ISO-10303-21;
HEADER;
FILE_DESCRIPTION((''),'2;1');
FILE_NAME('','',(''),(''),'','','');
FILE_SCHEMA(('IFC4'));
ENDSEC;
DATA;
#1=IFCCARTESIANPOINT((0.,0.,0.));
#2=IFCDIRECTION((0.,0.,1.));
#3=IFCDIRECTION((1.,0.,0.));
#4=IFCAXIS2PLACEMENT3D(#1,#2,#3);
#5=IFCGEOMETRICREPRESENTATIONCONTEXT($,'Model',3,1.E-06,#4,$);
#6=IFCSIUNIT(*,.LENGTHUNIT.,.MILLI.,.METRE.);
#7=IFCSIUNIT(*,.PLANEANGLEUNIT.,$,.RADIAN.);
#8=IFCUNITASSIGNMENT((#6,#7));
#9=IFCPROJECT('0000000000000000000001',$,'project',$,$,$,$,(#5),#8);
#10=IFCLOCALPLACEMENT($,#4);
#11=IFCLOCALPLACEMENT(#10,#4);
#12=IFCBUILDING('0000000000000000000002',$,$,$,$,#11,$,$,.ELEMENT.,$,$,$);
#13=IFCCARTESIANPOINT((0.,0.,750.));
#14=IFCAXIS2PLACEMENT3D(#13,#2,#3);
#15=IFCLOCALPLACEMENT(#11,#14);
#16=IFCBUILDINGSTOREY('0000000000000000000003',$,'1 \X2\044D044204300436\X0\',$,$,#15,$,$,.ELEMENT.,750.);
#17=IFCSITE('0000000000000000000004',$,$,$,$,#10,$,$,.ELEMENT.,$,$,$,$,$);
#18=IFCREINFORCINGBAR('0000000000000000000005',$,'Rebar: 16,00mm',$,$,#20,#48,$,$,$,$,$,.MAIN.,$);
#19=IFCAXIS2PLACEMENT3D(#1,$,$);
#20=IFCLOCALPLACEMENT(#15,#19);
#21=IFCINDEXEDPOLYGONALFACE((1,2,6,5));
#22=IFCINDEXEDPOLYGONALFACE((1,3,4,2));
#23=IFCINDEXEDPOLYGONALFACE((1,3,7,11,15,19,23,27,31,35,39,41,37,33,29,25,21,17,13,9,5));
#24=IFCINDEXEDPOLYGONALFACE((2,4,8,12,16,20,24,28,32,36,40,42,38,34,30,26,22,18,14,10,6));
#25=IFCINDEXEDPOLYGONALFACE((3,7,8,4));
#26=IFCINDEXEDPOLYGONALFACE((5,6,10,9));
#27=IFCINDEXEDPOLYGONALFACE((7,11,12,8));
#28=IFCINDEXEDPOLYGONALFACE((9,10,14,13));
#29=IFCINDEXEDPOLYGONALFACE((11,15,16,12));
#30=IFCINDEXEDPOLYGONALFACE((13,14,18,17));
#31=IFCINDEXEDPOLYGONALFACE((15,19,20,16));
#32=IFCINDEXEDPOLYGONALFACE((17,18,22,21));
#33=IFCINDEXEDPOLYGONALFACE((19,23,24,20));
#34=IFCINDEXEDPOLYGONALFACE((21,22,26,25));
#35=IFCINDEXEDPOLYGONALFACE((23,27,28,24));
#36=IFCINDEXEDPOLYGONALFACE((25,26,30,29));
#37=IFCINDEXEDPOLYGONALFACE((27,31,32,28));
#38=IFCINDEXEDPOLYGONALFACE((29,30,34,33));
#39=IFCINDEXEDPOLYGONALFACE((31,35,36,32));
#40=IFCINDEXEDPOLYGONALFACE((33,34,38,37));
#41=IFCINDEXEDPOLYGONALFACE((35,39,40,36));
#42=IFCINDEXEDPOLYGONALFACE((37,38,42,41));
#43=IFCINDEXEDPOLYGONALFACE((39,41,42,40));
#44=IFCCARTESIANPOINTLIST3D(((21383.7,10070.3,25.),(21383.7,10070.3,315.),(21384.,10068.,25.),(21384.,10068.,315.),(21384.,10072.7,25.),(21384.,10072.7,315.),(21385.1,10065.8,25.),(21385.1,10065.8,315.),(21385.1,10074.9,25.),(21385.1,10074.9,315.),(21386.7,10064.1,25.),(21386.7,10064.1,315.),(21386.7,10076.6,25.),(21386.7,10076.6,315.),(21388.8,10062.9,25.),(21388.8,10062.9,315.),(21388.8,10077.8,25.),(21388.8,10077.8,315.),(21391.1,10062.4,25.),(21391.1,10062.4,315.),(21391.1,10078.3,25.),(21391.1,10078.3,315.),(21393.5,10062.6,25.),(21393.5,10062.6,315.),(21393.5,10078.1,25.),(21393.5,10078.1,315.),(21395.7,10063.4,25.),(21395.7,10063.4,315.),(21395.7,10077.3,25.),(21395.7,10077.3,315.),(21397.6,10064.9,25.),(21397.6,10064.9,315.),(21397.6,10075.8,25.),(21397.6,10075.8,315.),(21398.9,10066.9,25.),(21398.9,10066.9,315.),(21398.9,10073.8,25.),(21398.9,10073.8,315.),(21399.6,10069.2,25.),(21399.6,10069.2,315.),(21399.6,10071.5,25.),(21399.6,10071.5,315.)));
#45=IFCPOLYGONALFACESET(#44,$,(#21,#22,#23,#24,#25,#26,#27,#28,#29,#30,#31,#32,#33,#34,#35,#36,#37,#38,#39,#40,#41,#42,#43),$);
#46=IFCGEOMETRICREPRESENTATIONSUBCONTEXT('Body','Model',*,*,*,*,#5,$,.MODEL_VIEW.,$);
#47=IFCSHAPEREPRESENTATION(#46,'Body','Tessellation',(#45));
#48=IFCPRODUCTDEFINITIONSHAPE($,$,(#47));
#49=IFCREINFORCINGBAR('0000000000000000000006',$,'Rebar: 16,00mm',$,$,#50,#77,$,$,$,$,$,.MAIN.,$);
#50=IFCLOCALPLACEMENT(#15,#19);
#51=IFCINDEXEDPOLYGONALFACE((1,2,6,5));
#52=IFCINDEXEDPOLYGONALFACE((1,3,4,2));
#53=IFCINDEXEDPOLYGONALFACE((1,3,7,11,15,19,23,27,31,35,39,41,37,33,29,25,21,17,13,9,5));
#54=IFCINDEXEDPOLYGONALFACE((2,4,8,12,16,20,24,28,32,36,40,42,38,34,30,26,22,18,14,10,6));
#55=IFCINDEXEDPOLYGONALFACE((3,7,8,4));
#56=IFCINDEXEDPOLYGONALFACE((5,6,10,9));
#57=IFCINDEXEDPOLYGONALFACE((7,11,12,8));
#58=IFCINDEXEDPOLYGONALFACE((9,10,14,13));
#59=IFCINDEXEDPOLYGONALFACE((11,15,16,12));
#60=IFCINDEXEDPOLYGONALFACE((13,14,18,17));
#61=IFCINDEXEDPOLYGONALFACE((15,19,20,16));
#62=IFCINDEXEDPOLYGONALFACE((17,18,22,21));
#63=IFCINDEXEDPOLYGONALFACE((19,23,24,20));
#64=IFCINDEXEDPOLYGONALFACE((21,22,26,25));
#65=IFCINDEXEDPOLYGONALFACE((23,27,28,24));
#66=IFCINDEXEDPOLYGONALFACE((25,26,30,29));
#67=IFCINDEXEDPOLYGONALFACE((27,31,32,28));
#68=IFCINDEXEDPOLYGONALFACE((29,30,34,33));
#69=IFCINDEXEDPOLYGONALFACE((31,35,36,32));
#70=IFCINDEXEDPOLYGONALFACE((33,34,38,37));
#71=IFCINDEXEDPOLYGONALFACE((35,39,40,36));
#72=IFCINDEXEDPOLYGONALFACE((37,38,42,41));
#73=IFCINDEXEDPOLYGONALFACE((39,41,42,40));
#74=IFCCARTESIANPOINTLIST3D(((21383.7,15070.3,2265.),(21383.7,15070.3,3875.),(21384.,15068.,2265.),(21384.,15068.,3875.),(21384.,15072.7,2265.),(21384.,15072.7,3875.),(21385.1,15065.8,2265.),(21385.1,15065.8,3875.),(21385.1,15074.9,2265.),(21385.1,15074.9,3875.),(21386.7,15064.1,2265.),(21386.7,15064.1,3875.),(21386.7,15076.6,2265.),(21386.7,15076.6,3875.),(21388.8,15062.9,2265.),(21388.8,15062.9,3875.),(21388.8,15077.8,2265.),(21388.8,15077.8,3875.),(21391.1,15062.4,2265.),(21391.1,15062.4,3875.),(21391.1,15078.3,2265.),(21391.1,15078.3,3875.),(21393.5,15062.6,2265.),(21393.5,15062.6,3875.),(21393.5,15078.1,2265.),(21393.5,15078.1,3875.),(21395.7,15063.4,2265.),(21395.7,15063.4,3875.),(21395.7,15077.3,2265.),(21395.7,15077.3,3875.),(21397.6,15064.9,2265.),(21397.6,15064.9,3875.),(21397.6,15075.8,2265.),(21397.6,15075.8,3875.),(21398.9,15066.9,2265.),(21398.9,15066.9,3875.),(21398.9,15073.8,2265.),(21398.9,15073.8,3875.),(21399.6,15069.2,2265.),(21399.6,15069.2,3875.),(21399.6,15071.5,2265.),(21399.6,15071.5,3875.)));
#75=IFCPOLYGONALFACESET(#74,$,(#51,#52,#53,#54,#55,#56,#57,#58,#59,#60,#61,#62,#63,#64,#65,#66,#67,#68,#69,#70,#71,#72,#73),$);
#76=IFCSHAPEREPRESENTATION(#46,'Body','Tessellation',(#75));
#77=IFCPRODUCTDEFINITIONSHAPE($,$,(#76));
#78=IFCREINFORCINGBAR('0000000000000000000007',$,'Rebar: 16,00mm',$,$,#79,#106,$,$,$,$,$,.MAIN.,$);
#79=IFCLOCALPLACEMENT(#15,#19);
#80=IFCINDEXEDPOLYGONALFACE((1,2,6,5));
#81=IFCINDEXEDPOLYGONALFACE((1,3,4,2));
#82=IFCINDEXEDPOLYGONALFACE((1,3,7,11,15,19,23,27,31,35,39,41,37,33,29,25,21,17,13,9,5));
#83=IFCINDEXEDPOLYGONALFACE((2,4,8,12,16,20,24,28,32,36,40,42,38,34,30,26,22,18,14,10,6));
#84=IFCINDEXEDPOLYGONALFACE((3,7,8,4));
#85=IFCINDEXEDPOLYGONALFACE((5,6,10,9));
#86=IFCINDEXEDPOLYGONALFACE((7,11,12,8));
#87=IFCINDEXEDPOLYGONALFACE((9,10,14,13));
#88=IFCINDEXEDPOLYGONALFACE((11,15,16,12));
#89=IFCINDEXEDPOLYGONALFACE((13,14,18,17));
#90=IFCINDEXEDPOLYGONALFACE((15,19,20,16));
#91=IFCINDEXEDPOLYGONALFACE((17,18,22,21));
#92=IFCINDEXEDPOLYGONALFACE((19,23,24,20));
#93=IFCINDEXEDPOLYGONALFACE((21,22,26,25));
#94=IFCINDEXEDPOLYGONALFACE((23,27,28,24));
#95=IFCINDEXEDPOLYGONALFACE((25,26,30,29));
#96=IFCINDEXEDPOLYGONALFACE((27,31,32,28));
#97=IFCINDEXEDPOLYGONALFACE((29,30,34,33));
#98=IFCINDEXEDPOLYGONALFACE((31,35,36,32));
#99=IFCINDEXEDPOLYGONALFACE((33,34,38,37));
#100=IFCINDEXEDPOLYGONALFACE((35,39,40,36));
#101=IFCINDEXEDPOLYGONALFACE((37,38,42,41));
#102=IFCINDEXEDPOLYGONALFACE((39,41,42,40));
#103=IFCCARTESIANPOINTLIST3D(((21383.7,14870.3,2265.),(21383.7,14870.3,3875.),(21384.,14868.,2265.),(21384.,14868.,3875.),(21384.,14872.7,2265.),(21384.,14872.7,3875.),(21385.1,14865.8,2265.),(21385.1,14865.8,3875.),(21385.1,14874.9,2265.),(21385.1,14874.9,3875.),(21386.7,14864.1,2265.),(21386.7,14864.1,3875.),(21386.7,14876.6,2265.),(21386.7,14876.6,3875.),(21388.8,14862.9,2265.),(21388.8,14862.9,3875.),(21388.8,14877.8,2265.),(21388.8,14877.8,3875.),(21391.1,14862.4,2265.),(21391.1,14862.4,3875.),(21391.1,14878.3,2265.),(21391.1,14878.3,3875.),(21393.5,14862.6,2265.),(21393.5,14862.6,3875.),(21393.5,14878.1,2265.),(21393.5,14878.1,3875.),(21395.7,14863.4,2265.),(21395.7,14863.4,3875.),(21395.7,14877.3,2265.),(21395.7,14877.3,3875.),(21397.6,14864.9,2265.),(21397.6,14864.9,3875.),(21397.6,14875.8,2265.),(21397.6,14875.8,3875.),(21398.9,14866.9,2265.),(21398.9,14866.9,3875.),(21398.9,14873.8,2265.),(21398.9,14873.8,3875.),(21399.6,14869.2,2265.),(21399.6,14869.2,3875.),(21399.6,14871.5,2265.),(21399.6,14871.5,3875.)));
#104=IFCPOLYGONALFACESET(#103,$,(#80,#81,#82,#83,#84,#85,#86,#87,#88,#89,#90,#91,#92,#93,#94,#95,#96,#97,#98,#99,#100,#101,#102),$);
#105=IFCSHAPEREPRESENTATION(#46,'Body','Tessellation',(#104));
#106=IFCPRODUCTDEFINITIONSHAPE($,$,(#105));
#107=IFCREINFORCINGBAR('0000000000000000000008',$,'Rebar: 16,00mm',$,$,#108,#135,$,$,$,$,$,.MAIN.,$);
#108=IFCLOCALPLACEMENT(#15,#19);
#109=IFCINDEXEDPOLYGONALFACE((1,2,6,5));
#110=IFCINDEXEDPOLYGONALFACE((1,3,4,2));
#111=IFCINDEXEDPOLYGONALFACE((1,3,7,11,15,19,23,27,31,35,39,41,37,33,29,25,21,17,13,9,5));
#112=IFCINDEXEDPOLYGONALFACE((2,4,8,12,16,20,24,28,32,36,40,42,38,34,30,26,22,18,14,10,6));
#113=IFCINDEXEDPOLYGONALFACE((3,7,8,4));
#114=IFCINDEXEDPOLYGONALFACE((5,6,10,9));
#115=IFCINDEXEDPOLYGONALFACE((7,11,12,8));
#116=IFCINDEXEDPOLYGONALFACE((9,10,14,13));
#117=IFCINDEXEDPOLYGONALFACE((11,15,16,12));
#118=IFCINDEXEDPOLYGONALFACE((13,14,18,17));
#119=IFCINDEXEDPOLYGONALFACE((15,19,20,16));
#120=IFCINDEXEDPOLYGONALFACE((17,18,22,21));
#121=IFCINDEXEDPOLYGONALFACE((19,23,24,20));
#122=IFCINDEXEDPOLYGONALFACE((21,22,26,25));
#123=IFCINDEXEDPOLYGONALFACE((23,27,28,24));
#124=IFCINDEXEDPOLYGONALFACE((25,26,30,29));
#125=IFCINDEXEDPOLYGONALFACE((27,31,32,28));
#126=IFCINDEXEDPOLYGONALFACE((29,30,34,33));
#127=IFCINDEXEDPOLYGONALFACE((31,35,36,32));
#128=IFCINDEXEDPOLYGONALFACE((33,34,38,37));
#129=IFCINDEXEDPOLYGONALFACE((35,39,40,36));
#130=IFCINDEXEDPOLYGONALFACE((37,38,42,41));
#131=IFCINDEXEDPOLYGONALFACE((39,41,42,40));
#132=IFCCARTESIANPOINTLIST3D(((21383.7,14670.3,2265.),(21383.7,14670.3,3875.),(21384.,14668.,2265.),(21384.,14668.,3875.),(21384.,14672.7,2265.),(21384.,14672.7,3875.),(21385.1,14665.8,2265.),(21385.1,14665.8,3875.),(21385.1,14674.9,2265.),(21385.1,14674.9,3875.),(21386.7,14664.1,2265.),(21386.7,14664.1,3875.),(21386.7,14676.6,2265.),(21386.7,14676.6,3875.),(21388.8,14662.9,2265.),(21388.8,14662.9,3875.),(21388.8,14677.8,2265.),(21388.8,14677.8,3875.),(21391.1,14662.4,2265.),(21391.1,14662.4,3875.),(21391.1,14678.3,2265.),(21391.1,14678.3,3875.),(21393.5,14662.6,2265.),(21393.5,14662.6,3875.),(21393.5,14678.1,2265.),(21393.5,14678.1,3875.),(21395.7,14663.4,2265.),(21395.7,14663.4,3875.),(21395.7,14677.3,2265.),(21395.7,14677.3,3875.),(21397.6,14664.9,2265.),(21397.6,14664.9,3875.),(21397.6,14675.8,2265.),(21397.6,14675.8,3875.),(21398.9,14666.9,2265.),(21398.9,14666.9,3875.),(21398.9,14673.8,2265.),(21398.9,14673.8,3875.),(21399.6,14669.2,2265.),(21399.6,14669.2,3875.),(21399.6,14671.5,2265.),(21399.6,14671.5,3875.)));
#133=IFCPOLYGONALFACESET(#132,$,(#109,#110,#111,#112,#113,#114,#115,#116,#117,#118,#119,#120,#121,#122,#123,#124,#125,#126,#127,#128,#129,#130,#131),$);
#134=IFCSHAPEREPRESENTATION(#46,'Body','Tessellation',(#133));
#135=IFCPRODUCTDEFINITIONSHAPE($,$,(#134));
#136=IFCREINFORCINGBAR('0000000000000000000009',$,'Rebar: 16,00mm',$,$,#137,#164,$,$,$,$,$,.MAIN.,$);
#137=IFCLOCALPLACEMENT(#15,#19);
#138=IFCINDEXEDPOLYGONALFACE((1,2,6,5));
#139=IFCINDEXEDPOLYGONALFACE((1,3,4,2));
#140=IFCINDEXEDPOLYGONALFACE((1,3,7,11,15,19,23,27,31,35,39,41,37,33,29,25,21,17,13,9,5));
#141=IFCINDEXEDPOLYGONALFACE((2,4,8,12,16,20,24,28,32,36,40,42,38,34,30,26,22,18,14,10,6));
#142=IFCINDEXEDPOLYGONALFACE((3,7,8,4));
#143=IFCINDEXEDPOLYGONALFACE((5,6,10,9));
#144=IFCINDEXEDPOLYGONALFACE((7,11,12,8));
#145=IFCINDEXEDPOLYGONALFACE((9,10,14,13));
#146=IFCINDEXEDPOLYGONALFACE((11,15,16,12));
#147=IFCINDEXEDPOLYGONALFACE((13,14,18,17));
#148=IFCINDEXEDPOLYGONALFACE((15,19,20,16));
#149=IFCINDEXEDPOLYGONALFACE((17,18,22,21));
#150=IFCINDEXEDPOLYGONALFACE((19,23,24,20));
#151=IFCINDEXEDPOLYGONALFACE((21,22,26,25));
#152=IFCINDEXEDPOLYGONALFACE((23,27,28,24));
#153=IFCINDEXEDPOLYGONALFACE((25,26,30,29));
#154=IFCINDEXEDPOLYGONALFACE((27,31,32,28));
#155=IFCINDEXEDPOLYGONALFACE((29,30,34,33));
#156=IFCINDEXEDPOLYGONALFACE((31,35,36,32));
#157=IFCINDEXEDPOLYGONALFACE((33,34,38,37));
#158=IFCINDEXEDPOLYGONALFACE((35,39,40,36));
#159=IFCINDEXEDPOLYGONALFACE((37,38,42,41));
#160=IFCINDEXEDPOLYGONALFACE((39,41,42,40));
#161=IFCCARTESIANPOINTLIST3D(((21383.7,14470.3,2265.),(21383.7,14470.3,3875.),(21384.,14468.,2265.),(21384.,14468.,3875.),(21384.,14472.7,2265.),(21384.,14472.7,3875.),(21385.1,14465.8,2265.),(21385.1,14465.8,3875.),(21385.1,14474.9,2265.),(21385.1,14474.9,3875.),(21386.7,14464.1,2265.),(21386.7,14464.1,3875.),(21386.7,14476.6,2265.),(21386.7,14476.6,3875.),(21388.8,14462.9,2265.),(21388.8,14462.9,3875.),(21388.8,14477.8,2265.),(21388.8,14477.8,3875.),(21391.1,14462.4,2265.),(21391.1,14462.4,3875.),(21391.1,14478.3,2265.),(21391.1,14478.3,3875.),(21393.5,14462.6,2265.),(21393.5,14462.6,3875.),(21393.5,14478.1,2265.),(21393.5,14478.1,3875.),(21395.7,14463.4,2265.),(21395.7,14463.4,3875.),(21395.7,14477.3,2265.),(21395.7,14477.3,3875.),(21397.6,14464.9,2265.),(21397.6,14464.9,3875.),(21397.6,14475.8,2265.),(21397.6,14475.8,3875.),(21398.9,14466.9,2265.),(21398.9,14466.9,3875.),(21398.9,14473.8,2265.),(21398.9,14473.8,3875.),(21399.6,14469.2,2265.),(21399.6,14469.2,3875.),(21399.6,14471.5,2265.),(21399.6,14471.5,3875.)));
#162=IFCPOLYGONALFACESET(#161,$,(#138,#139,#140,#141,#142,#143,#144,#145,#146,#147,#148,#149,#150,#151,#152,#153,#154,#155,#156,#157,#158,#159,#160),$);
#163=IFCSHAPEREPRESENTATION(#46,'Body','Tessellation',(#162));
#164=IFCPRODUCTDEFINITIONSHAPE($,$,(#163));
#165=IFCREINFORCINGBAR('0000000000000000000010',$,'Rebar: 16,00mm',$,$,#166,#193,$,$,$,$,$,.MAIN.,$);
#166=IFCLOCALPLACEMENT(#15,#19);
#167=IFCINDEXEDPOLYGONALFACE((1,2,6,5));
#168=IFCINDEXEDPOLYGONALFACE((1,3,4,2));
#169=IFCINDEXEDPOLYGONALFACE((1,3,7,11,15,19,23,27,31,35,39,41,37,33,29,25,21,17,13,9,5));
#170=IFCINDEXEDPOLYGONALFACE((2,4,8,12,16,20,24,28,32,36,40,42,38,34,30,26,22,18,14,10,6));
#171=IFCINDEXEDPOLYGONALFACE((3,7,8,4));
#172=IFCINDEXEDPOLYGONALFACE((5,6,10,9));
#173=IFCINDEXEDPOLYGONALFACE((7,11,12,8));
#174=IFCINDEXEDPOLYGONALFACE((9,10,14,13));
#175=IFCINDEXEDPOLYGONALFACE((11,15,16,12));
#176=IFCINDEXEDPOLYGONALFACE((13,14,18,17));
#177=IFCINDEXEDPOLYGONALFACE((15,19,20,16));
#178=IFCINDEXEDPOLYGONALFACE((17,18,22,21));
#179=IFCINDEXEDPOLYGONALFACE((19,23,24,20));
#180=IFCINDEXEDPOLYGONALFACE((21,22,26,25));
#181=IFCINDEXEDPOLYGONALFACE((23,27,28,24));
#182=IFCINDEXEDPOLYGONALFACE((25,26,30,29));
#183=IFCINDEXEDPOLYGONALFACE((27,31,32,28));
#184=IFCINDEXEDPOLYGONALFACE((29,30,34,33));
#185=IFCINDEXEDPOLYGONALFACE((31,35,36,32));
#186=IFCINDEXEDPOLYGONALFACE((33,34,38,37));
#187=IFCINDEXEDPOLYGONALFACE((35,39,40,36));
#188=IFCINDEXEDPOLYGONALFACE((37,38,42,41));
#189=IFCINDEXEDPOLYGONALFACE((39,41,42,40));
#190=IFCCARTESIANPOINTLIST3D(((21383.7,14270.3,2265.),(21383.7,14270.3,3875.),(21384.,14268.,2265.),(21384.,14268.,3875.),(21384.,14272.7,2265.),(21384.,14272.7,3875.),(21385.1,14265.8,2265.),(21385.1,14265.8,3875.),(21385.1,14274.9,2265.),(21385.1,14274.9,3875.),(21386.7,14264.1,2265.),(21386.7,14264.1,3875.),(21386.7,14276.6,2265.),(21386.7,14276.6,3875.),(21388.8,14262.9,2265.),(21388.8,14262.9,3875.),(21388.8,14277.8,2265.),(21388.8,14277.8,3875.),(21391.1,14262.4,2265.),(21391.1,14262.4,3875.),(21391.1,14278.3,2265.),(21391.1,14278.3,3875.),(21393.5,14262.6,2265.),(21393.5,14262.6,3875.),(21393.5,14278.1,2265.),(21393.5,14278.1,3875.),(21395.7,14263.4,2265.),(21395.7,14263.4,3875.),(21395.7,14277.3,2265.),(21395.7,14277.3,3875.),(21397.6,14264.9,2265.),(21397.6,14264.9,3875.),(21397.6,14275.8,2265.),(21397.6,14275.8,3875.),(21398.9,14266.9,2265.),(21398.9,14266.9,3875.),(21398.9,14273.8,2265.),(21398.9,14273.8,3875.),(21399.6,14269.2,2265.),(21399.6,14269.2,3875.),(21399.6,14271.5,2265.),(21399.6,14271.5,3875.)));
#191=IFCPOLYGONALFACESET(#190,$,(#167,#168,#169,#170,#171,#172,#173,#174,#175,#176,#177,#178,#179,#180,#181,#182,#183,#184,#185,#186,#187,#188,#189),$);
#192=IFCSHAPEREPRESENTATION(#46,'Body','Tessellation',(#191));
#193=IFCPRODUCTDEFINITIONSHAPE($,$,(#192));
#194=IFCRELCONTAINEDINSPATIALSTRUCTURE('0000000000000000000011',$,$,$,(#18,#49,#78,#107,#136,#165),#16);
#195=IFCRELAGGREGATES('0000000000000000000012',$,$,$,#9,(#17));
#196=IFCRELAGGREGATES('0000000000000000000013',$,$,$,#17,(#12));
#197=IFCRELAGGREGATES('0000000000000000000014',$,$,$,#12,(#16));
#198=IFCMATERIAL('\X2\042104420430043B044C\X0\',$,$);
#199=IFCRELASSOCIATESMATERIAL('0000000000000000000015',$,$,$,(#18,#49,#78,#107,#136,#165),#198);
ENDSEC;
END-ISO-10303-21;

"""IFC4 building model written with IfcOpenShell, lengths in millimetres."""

from ifc_helpers import new_model, entity, si_unit, frame, origin_with_axes, place, context, subcontext, project, spatial, source, transform, mapped, material, element, save


model = new_model("IFC4")

# Units and contexts
model_context = context("Model", 3, precision=1e-06, world=origin_with_axes())
body_context = subcontext(model_context, "Body", "Model", "MODEL_VIEW")
ifc_project = project(units=[si_unit("LENGTHUNIT", "METRE", prefix="MILLI"), si_unit("PLANEANGLEUNIT", "RADIAN")], contexts=[model_context])

# Site, building, storey
site_placement = place(None, origin_with_axes())
site = spatial("IfcSite", under=ifc_project, at=site_placement, CompositionType="ELEMENT")
building_placement = place(site_placement, origin_with_axes())
building = spatial("IfcBuilding", under=site, at=building_placement, CompositionType="ELEMENT")
storey_placement = place(building_placement, frame((0.0, 0.0, 750.0), z_axis=(0.0, 0.0, 1.0), x_axis=(1.0, 0.0, 0.0)))
storey = spatial("IfcBuildingStorey", under=building, at=storey_placement, Name="1 этаж", CompositionType="ELEMENT", Elevation=750.0)

# Reinforcing bars
ifc_material = material(Name="Сталь")
shared_shape_1 = source(origin_with_axes(), body_context, "Body", "AdvancedSweptSolid", [
    entity("IfcSweptDiskSolid", entity("IfcIndexedPolyCurve", entity("IfcCartesianPointList3D", [[0.0, 0.0, 0.0], [290.0, 0.0, 0.0]]), [entity("IfcLineIndex", [1, 2])]), 8.0),
])
reinforcing_bar_1_placement = place(storey_placement, origin_with_axes())
element("IfcReinforcingBar", 1, at=reinforcing_bar_1_placement, inside=storey, material=ifc_material, Name="Rebar: 16,00mm", PredefinedType="MAIN", context=body_context, shape_type="MappedRepresentation", body=[
    mapped(shared_shape_1, transform((21391.7, 10070.3, 25.0), x_axis=(0.0, 0.0, 1.0), y_axis=(0.0, 1.0, 0.0), z_axis=(-1.0, 0.0, 0.0), scale=1.0)),
])
shared_shape_2 = source(origin_with_axes(), body_context, "Body", "AdvancedSweptSolid", [
    entity("IfcSweptDiskSolid", entity("IfcIndexedPolyCurve", entity("IfcCartesianPointList3D", [[0.0, 0.0, 0.0], [1610.0, 0.0, 0.0]]), [entity("IfcLineIndex", [1, 2])]), 8.0),
])
reinforcing_bar_2_placement = place(storey_placement, origin_with_axes())
element("IfcReinforcingBar", 2, at=reinforcing_bar_2_placement, inside=storey, material=ifc_material, Name="Rebar: 16,00mm", PredefinedType="MAIN", context=body_context, shape_type="MappedRepresentation", body=[
    mapped(shared_shape_2, transform((21391.7, 15070.3, 2265.0), x_axis=(0.0, 0.0, 1.0), y_axis=(0.0, 1.0, 0.0), z_axis=(-1.0, 0.0, 0.0), scale=1.0)),
])
reinforcing_bar_3_placement = place(storey_placement, origin_with_axes())
element("IfcReinforcingBar", 3, at=reinforcing_bar_3_placement, inside=storey, material=ifc_material, Name="Rebar: 16,00mm", PredefinedType="MAIN", context=body_context, shape_type="MappedRepresentation", body=[
    mapped(shared_shape_2, transform((21391.7, 14870.3, 2265.0), x_axis=(0.0, 0.0, 1.0), y_axis=(0.0, 1.0, 0.0), z_axis=(-1.0, 0.0, 0.0), scale=1.0)),
])
reinforcing_bar_4_placement = place(storey_placement, origin_with_axes())
element("IfcReinforcingBar", 4, at=reinforcing_bar_4_placement, inside=storey, material=ifc_material, Name="Rebar: 16,00mm", PredefinedType="MAIN", context=body_context, shape_type="MappedRepresentation", body=[
    mapped(shared_shape_2, transform((21391.7, 14670.3, 2265.0), x_axis=(0.0, 0.0, 1.0), y_axis=(0.0, 1.0, 0.0), z_axis=(-1.0, 0.0, 0.0), scale=1.0)),
])
reinforcing_bar_5_placement = place(storey_placement, origin_with_axes())
element("IfcReinforcingBar", 5, at=reinforcing_bar_5_placement, inside=storey, material=ifc_material, Name="Rebar: 16,00mm", PredefinedType="MAIN", context=body_context, shape_type="MappedRepresentation", body=[
    mapped(shared_shape_2, transform((21391.7, 14470.3, 2265.0), x_axis=(0.0, 0.0, 1.0), y_axis=(0.0, 1.0, 0.0), z_axis=(-1.0, 0.0, 0.0), scale=1.0)),
])
reinforcing_bar_6_placement = place(storey_placement, origin_with_axes())
element("IfcReinforcingBar", 6, at=reinforcing_bar_6_placement, inside=storey, material=ifc_material, Name="Rebar: 16,00mm", PredefinedType="MAIN", context=body_context, shape_type="MappedRepresentation", body=[
    mapped(shared_shape_2, transform((21391.7, 14270.3, 2265.0), x_axis=(0.0, 0.0, 1.0), y_axis=(0.0, 1.0, 0.0), z_axis=(-1.0, 0.0, 0.0), scale=1.0)),
])

save(model, "model.ifc")
